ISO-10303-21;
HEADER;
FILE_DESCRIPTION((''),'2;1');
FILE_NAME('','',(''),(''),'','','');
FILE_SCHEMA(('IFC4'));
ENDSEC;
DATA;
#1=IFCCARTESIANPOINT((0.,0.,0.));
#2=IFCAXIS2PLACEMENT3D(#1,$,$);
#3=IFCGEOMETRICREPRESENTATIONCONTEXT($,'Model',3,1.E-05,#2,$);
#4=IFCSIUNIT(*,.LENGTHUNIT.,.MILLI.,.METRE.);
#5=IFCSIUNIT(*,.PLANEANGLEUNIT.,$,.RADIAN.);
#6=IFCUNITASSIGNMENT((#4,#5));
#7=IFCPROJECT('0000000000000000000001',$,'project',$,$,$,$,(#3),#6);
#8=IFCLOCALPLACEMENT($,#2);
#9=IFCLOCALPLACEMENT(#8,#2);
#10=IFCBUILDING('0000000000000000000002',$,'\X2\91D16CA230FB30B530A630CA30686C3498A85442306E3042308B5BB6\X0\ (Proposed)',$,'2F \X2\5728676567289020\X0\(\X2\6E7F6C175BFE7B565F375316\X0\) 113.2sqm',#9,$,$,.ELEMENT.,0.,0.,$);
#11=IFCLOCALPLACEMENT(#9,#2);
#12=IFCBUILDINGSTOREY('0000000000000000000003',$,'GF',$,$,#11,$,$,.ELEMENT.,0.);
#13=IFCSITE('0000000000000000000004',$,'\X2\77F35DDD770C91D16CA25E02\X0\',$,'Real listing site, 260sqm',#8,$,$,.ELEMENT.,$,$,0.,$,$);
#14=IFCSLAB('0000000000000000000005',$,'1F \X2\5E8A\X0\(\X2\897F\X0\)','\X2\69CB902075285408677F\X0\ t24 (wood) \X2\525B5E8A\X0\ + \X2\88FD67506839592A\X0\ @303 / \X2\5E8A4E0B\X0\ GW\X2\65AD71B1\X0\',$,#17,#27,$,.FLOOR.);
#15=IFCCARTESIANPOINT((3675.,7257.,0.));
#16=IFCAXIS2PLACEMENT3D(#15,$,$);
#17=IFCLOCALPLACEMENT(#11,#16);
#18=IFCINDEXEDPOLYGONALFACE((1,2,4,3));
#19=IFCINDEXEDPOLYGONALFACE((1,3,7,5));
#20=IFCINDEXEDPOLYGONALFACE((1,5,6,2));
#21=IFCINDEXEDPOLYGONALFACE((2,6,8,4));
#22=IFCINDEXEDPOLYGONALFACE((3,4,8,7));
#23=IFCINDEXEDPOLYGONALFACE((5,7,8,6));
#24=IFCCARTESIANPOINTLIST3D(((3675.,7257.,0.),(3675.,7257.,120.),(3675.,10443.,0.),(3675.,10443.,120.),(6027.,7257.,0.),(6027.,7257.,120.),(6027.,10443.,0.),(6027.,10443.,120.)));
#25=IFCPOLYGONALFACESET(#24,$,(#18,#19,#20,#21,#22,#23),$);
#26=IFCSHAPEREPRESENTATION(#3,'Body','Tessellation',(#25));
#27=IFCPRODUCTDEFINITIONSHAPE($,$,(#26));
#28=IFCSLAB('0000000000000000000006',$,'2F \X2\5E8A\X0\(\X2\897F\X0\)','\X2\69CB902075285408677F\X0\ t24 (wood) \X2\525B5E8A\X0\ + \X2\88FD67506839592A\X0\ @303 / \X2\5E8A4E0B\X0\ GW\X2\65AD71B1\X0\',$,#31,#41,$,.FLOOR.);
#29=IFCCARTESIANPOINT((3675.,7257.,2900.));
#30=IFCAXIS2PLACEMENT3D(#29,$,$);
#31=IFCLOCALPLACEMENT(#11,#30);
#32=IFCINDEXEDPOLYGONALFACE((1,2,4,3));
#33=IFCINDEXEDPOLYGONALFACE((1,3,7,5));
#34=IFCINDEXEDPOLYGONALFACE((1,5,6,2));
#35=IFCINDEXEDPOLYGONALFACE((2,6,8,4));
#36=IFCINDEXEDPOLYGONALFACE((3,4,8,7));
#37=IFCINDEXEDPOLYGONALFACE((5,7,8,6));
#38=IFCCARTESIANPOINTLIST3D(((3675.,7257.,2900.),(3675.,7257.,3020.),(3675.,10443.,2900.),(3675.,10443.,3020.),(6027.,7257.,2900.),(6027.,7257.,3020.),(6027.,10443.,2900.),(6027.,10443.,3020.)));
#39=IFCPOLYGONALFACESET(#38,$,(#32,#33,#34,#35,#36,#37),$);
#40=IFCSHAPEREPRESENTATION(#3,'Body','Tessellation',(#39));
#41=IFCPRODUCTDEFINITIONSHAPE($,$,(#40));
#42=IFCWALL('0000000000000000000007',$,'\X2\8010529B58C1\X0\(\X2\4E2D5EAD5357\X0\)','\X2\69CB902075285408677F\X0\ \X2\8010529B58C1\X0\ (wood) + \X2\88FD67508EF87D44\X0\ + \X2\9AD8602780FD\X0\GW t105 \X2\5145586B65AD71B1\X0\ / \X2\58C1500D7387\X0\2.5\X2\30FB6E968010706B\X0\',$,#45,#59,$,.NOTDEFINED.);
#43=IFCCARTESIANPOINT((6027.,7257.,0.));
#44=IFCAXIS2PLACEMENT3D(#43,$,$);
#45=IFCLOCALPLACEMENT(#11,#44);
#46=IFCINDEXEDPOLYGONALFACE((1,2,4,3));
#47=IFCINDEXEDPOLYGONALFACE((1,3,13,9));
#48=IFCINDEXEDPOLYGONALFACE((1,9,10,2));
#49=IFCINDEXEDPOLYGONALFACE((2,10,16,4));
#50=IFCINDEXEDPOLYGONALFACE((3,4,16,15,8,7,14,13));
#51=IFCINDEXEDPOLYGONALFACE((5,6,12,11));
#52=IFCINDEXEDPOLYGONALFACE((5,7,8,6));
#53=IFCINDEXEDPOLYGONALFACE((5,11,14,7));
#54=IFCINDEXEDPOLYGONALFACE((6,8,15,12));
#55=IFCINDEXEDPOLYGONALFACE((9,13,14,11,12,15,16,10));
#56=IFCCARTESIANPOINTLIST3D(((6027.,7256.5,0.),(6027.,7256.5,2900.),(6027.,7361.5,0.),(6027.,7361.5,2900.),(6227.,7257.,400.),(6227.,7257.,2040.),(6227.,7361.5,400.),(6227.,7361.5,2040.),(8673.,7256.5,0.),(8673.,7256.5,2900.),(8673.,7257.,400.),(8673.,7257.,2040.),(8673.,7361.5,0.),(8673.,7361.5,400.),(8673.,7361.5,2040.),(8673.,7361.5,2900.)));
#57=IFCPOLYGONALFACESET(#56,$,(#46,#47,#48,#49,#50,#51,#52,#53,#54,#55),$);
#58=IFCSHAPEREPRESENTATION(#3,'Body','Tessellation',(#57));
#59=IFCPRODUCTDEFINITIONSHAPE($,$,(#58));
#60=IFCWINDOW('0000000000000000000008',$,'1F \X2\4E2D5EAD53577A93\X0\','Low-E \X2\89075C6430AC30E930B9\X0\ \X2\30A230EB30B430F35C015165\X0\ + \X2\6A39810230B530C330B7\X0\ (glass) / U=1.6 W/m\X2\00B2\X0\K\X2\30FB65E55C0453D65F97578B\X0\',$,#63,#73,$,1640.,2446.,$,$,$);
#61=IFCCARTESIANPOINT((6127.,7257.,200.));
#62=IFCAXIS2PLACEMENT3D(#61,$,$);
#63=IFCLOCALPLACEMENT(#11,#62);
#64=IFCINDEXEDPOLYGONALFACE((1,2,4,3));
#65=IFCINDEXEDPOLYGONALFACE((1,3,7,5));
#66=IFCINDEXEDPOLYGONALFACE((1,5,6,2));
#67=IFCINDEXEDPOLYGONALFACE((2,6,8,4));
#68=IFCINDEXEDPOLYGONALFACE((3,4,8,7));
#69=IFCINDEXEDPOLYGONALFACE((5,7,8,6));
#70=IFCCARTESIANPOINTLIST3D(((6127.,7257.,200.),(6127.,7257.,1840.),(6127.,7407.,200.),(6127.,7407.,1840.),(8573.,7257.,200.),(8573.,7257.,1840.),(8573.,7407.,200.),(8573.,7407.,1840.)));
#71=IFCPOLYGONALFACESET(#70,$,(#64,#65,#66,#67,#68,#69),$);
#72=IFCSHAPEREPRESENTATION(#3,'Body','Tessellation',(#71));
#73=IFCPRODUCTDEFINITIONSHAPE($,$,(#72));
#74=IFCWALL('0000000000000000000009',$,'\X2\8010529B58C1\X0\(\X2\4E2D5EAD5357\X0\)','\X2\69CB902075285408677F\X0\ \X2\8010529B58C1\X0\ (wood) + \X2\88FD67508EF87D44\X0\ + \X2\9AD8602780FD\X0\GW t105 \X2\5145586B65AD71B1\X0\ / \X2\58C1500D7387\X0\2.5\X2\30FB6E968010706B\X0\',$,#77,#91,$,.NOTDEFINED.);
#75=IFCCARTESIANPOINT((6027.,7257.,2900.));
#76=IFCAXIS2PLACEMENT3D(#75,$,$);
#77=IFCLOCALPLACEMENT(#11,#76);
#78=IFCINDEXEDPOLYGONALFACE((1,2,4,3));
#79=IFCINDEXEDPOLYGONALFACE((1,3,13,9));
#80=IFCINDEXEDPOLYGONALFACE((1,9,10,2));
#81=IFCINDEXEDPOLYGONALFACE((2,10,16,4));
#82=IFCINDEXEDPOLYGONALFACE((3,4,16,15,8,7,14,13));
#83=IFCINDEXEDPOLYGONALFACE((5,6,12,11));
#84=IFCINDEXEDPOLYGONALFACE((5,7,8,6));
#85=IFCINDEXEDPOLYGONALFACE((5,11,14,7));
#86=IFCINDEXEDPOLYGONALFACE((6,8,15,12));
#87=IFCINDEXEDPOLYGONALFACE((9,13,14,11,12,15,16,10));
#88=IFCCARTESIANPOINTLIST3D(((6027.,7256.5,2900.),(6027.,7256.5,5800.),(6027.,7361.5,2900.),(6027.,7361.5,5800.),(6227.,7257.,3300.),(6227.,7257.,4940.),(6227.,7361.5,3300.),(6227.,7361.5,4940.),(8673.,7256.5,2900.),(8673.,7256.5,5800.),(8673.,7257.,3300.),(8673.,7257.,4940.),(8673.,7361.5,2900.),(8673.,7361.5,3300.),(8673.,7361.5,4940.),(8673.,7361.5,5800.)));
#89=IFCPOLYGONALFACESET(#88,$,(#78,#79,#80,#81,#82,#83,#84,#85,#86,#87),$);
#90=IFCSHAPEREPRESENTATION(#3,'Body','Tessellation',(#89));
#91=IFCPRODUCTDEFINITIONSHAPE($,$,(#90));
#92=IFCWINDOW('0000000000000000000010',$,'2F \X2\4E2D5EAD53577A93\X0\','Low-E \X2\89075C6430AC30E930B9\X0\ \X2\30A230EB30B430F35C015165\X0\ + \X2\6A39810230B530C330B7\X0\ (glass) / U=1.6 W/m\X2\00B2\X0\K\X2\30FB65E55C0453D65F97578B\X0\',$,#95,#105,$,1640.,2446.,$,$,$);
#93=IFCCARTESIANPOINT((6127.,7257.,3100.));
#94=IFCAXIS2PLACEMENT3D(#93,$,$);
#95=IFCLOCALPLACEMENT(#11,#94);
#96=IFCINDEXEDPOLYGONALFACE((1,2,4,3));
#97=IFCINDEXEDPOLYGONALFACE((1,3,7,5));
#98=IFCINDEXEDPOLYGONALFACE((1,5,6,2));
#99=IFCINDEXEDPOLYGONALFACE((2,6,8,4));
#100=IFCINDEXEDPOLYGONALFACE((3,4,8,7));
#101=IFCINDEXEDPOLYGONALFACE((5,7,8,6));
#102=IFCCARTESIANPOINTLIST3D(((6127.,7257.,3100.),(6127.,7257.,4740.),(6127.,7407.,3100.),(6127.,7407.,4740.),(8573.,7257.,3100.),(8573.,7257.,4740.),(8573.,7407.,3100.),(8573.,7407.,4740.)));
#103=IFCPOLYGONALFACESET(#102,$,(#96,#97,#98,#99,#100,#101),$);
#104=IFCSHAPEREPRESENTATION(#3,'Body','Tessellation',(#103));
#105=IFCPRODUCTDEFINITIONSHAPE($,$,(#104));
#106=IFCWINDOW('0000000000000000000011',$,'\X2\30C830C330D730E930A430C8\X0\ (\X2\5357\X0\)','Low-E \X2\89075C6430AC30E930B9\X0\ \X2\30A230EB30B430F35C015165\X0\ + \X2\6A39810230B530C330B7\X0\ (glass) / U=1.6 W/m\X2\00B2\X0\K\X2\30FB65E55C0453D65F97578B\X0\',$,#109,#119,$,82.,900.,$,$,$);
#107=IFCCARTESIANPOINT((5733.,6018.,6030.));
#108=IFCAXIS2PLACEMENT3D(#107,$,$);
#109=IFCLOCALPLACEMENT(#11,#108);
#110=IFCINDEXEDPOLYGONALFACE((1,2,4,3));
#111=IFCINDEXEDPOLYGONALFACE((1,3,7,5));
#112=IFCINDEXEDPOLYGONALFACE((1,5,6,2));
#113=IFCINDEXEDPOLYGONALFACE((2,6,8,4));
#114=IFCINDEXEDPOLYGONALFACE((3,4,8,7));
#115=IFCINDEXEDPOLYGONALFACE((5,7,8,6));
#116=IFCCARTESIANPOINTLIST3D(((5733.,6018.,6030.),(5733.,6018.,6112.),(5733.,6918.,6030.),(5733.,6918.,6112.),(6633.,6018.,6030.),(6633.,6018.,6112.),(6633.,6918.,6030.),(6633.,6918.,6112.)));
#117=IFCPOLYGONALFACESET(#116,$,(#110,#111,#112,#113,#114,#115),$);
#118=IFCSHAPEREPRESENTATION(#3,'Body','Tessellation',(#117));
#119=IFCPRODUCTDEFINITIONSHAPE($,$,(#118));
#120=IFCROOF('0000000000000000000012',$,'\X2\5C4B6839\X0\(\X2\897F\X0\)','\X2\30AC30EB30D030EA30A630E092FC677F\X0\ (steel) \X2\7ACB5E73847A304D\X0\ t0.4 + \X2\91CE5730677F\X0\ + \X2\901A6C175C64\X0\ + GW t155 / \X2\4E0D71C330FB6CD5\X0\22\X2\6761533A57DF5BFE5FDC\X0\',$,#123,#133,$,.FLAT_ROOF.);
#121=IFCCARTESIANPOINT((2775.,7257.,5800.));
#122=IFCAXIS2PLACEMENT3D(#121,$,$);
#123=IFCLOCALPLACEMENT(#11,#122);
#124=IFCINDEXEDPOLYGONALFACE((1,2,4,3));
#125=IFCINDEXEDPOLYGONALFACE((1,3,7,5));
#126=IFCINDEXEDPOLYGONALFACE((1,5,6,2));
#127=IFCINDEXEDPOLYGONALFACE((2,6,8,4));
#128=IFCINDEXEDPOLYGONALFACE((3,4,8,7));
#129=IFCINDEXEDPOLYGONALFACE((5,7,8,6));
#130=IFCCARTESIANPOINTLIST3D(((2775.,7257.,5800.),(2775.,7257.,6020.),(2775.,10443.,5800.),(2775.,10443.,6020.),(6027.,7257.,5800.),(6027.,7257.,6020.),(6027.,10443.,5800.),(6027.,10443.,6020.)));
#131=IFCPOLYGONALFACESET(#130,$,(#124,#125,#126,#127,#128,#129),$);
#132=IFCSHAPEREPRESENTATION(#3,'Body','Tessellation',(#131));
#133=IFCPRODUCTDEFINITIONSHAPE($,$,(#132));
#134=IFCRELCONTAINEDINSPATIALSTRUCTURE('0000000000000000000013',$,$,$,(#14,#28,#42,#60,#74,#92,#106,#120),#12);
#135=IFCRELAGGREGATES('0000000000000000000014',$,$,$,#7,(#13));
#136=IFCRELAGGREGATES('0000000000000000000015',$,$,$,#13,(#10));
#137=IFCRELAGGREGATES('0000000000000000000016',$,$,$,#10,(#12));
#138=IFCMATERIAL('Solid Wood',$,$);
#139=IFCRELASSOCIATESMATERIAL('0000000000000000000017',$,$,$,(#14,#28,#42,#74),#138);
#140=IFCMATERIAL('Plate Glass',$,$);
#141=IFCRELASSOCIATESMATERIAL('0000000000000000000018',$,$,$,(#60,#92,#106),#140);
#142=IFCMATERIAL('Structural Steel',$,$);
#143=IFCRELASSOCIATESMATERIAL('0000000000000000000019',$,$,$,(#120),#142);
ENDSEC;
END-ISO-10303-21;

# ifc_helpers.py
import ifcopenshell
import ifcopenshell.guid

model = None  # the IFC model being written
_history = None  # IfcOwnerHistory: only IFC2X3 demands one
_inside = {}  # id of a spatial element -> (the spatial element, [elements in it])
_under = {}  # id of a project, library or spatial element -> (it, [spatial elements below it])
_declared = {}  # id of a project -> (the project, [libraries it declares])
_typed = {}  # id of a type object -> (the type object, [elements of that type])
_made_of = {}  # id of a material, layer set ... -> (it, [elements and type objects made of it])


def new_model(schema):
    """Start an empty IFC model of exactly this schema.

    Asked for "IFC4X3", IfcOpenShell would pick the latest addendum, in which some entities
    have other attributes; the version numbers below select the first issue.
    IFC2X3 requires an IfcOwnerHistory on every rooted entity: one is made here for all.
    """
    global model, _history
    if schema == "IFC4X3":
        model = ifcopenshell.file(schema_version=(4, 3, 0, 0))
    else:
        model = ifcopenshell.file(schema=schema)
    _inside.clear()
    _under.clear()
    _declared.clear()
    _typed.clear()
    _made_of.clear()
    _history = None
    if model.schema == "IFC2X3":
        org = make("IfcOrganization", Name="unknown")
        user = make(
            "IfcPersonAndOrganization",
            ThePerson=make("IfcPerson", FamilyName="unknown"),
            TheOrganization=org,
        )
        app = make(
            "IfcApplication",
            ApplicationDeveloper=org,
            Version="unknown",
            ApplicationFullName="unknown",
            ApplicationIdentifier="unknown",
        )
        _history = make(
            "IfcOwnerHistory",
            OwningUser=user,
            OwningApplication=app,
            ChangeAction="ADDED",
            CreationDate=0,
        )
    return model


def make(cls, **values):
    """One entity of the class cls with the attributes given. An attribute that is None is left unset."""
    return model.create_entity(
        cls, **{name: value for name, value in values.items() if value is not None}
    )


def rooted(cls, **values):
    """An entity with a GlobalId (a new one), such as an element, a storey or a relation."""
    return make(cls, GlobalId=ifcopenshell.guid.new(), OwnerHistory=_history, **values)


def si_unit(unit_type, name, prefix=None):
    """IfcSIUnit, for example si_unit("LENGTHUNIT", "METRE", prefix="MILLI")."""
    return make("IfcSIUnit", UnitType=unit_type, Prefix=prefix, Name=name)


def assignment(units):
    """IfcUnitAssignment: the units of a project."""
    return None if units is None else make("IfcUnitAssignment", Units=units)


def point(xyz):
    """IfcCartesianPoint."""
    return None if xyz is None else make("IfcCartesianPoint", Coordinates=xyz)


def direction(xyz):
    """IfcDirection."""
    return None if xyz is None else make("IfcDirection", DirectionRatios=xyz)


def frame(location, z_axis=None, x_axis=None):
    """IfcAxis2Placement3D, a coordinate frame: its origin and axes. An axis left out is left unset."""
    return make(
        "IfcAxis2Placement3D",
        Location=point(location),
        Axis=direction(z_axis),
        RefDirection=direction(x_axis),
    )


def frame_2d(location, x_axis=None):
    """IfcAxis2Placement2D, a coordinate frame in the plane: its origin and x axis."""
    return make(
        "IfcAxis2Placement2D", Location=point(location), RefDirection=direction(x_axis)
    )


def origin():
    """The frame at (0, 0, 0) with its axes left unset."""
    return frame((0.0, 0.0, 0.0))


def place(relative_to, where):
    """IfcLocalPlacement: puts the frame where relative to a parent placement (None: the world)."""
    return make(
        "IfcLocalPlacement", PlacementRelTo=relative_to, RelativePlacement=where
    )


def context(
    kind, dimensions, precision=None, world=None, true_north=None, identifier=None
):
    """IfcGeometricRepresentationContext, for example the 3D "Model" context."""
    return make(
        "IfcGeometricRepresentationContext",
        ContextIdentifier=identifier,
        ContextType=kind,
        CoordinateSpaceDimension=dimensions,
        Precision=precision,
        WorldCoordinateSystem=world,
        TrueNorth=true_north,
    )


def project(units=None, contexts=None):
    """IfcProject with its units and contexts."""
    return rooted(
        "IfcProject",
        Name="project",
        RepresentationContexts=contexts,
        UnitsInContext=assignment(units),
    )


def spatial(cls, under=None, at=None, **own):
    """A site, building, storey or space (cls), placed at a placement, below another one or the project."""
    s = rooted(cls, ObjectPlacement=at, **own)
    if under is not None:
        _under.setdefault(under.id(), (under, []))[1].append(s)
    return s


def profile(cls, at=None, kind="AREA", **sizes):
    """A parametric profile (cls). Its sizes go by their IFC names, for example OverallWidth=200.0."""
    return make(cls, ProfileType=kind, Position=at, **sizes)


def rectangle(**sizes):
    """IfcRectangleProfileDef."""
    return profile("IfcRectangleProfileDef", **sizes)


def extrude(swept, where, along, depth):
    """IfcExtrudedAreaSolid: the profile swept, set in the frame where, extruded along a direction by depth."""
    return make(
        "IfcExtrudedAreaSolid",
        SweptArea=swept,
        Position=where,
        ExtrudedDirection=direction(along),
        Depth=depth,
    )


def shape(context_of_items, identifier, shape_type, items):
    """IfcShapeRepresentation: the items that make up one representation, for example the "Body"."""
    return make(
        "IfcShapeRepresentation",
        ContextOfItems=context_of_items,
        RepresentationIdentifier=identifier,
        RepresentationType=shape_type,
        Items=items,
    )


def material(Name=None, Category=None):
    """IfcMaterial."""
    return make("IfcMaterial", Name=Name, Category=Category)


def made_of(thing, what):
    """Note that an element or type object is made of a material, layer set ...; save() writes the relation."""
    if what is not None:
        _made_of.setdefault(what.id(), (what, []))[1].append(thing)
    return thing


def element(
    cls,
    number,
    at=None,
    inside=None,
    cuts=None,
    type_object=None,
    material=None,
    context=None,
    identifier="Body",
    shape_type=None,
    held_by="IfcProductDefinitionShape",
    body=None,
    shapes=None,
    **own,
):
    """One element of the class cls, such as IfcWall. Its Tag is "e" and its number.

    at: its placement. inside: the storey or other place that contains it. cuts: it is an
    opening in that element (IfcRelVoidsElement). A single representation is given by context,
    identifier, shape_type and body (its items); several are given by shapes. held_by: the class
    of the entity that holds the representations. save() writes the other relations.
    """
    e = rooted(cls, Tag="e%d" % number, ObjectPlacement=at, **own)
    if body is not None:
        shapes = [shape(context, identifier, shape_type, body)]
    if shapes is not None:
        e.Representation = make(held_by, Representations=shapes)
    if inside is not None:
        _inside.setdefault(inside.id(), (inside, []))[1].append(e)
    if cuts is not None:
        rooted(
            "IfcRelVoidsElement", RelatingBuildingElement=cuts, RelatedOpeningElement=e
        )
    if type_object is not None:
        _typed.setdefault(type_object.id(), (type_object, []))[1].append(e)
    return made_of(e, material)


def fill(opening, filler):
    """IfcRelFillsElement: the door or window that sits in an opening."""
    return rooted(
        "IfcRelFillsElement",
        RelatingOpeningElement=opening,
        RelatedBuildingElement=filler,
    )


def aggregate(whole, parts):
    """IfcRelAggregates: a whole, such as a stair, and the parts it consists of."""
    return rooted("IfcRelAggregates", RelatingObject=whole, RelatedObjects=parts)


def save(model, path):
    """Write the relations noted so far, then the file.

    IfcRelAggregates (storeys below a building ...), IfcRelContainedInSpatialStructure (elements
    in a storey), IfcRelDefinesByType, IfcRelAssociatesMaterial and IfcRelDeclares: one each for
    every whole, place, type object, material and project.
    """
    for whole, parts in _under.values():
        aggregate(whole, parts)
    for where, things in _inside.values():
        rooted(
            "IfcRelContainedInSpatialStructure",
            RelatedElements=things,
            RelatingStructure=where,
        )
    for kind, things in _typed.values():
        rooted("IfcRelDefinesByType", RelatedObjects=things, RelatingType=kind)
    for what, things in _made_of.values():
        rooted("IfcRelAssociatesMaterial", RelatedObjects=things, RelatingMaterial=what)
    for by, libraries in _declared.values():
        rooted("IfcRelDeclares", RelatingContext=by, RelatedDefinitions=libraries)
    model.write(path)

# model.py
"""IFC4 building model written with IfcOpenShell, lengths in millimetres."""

from ifc_helpers import new_model, si_unit, frame, frame_2d, origin, place, context, project, spatial, rectangle, extrude, material, element, fill, save


model = new_model("IFC4")

# Units and contexts
model_context = context("Model", 3, precision=1e-05, world=origin())
ifc_project = project(units=[si_unit("LENGTHUNIT", "METRE", prefix="MILLI"), si_unit("PLANEANGLEUNIT", "RADIAN")], contexts=[model_context])

# Site, building, storey
site_placement = place(None, origin())
site = spatial("IfcSite", under=ifc_project, at=site_placement, Name="石川県金沢市", ObjectType="Real listing site, 260sqm", CompositionType="ELEMENT", RefElevation=0.0)
building_placement = place(site_placement, origin())
building = spatial("IfcBuilding", under=site, at=building_placement, Name="金沢・サウナと水風呂のある家 (Proposed)", ObjectType="2F 在来木造(湿気対策強化) 113.2sqm", CompositionType="ELEMENT", ElevationOfRefHeight=0.0, ElevationOfTerrain=0.0)
storey_placement = place(building_placement, origin())
storey = spatial("IfcBuildingStorey", under=building, at=storey_placement, Name="GF", CompositionType="ELEMENT", Elevation=0.0)

# Shared definitions
ifc_material_1 = material(Name="Solid Wood")

# Slabs
slab_1_placement = place(storey_placement, frame((3675.0, 7257.0, 0.0)))
element("IfcSlab", 1, at=slab_1_placement, inside=storey, material=ifc_material_1, Name="1F 床(西)", Description="構造用合板 t24 (wood) 剛床 + 製材根太 @303 / 床下 GW断熱", PredefinedType="FLOOR", context=model_context, shape_type="SweptSolid", body=[
    extrude(rectangle(XDim=2352.0, YDim=3186.0, at=frame_2d((1176.0, 1593.0))), frame((3675.0, 7257.0, 0.0)), (0.0, 0.0, 1.0), 120.0),
])
slab_2_placement = place(storey_placement, frame((3675.0, 7257.0, 2900.0)))
element("IfcSlab", 2, at=slab_2_placement, inside=storey, material=ifc_material_1, Name="2F 床(西)", Description="構造用合板 t24 (wood) 剛床 + 製材根太 @303 / 床下 GW断熱", PredefinedType="FLOOR", context=model_context, shape_type="SweptSolid", body=[
    extrude(rectangle(XDim=2352.0, YDim=3186.0, at=frame_2d((1176.0, 1593.0))), frame((3675.0, 7257.0, 2900.0)), (0.0, 0.0, 1.0), 120.0),
])

# Wall, opening, window
wall_1_placement = place(storey_placement, frame((6027.0, 7257.0, 0.0)))
wall_1 = element("IfcWall", 3, at=wall_1_placement, inside=storey, material=ifc_material_1, Name="耐力壁(中庭南)", Description="構造用合板 耐力壁 (wood) + 製材軸組 + 高性能GW t105 充填断熱 / 壁倍率2.5・準耐火", PredefinedType="NOTDEFINED", context=model_context, shape_type="SweptSolid", body=[
    extrude(rectangle(XDim=2646.0, YDim=105.0, at=frame_2d((1323.0, 52.0))), frame((6027.0, 7257.0, 0.0)), (0.0, 0.0, 1.0), 2900.0),
])
opening_1_placement = place(storey_placement, frame((6127.0, 7257.0, 200.0)))
opening_1 = element("IfcOpeningElement", 4, at=opening_1_placement, cuts=wall_1, PredefinedType="NOTDEFINED", context=model_context, shape_type="SweptSolid", body=[
    extrude(rectangle(XDim=2446.0, YDim=150.0, at=frame_2d((1223.0, 75.0))), frame((6127.0, 7257.0, 200.0)), (0.0, 0.0, 1.0), 1640.0),
])
ifc_material_2 = material(Name="Plate Glass")
window_1_placement = place(storey_placement, frame((6127.0, 7257.0, 200.0)))
window_1 = element("IfcWindow", 5, at=window_1_placement, inside=storey, material=ifc_material_2, Name="1F 中庭南窓", Description="Low-E 複層ガラス アルゴン封入 + 樹脂サッシ (glass) / U=1.6 W/m²K・日射取得型", OverallHeight=1640.0, OverallWidth=2446.0, context=model_context, shape_type="SweptSolid", body=[
    extrude(rectangle(XDim=2446.0, YDim=150.0, at=frame_2d((1223.0, 75.0))), frame((6127.0, 7257.0, 200.0)), (0.0, 0.0, 1.0), 1640.0),
])
fill(opening_1, window_1)

# Wall, opening, window
wall_2_placement = place(storey_placement, frame((6027.0, 7257.0, 2900.0)))
wall_2 = element("IfcWall", 6, at=wall_2_placement, inside=storey, material=ifc_material_1, Name="耐力壁(中庭南)", Description="構造用合板 耐力壁 (wood) + 製材軸組 + 高性能GW t105 充填断熱 / 壁倍率2.5・準耐火", PredefinedType="NOTDEFINED", context=model_context, shape_type="SweptSolid", body=[
    extrude(rectangle(XDim=2646.0, YDim=105.0, at=frame_2d((1323.0, 52.0))), frame((6027.0, 7257.0, 2900.0)), (0.0, 0.0, 1.0), 2900.0),
])
opening_2_placement = place(storey_placement, frame((6127.0, 7257.0, 3100.0)))
opening_2 = element("IfcOpeningElement", 7, at=opening_2_placement, cuts=wall_2, PredefinedType="NOTDEFINED", context=model_context, shape_type="SweptSolid", body=[
    extrude(rectangle(XDim=2446.0, YDim=150.0, at=frame_2d((1223.0, 75.0))), frame((6127.0, 7257.0, 3100.0)), (0.0, 0.0, 1.0), 1640.0),
])
window_2_placement = place(storey_placement, frame((6127.0, 7257.0, 3100.0)))
window_2 = element("IfcWindow", 8, at=window_2_placement, inside=storey, material=ifc_material_2, Name="2F 中庭南窓", Description="Low-E 複層ガラス アルゴン封入 + 樹脂サッシ (glass) / U=1.6 W/m²K・日射取得型", OverallHeight=1640.0, OverallWidth=2446.0, context=model_context, shape_type="SweptSolid", body=[
    extrude(rectangle(XDim=2446.0, YDim=150.0, at=frame_2d((1223.0, 75.0))), frame((6127.0, 7257.0, 3100.0)), (0.0, 0.0, 1.0), 1640.0),
])
fill(opening_2, window_2)

# Window
window_3_placement = place(storey_placement, frame((5733.0, 6018.0, 6030.0)))
element("IfcWindow", 9, at=window_3_placement, inside=storey, material=ifc_material_2, Name="トップライト (南)", Description="Low-E 複層ガラス アルゴン封入 + 樹脂サッシ (glass) / U=1.6 W/m²K・日射取得型", OverallHeight=82.0, OverallWidth=900.0, context=model_context, shape_type="SweptSolid", body=[
    extrude(rectangle(XDim=900.0, YDim=900.0, at=frame_2d((450.0, 450.0))), frame((5733.0, 6018.0, 6030.0)), (0.0, 0.0, 1.0), 82.0),
])

# Roof
ifc_material_3 = material(Name="Structural Steel")
for number, where, name in (
    (10, (2775.0, 7257.0, 5800.0), "屋根(西)"),
):
    element("IfcRoof", number, at=place(storey_placement, frame(where)), inside=storey, material=ifc_material_3, Name=name, Description="ガルバリウム鋼板 (steel) 立平葺き t0.4 + 野地板 + 通気層 + GW t155 / 不燃・法22条区域対応", PredefinedType="FLAT_ROOF", context=model_context, shape_type="SweptSolid", body=[
        extrude(rectangle(XDim=3252.0, YDim=3186.0, at=frame_2d((1626.0, 1593.0))), frame((2775.0, 7257.0, 5800.0)), (0.0, 0.0, 1.0), 220.0),
    ])

save(model, "model.ifc")
